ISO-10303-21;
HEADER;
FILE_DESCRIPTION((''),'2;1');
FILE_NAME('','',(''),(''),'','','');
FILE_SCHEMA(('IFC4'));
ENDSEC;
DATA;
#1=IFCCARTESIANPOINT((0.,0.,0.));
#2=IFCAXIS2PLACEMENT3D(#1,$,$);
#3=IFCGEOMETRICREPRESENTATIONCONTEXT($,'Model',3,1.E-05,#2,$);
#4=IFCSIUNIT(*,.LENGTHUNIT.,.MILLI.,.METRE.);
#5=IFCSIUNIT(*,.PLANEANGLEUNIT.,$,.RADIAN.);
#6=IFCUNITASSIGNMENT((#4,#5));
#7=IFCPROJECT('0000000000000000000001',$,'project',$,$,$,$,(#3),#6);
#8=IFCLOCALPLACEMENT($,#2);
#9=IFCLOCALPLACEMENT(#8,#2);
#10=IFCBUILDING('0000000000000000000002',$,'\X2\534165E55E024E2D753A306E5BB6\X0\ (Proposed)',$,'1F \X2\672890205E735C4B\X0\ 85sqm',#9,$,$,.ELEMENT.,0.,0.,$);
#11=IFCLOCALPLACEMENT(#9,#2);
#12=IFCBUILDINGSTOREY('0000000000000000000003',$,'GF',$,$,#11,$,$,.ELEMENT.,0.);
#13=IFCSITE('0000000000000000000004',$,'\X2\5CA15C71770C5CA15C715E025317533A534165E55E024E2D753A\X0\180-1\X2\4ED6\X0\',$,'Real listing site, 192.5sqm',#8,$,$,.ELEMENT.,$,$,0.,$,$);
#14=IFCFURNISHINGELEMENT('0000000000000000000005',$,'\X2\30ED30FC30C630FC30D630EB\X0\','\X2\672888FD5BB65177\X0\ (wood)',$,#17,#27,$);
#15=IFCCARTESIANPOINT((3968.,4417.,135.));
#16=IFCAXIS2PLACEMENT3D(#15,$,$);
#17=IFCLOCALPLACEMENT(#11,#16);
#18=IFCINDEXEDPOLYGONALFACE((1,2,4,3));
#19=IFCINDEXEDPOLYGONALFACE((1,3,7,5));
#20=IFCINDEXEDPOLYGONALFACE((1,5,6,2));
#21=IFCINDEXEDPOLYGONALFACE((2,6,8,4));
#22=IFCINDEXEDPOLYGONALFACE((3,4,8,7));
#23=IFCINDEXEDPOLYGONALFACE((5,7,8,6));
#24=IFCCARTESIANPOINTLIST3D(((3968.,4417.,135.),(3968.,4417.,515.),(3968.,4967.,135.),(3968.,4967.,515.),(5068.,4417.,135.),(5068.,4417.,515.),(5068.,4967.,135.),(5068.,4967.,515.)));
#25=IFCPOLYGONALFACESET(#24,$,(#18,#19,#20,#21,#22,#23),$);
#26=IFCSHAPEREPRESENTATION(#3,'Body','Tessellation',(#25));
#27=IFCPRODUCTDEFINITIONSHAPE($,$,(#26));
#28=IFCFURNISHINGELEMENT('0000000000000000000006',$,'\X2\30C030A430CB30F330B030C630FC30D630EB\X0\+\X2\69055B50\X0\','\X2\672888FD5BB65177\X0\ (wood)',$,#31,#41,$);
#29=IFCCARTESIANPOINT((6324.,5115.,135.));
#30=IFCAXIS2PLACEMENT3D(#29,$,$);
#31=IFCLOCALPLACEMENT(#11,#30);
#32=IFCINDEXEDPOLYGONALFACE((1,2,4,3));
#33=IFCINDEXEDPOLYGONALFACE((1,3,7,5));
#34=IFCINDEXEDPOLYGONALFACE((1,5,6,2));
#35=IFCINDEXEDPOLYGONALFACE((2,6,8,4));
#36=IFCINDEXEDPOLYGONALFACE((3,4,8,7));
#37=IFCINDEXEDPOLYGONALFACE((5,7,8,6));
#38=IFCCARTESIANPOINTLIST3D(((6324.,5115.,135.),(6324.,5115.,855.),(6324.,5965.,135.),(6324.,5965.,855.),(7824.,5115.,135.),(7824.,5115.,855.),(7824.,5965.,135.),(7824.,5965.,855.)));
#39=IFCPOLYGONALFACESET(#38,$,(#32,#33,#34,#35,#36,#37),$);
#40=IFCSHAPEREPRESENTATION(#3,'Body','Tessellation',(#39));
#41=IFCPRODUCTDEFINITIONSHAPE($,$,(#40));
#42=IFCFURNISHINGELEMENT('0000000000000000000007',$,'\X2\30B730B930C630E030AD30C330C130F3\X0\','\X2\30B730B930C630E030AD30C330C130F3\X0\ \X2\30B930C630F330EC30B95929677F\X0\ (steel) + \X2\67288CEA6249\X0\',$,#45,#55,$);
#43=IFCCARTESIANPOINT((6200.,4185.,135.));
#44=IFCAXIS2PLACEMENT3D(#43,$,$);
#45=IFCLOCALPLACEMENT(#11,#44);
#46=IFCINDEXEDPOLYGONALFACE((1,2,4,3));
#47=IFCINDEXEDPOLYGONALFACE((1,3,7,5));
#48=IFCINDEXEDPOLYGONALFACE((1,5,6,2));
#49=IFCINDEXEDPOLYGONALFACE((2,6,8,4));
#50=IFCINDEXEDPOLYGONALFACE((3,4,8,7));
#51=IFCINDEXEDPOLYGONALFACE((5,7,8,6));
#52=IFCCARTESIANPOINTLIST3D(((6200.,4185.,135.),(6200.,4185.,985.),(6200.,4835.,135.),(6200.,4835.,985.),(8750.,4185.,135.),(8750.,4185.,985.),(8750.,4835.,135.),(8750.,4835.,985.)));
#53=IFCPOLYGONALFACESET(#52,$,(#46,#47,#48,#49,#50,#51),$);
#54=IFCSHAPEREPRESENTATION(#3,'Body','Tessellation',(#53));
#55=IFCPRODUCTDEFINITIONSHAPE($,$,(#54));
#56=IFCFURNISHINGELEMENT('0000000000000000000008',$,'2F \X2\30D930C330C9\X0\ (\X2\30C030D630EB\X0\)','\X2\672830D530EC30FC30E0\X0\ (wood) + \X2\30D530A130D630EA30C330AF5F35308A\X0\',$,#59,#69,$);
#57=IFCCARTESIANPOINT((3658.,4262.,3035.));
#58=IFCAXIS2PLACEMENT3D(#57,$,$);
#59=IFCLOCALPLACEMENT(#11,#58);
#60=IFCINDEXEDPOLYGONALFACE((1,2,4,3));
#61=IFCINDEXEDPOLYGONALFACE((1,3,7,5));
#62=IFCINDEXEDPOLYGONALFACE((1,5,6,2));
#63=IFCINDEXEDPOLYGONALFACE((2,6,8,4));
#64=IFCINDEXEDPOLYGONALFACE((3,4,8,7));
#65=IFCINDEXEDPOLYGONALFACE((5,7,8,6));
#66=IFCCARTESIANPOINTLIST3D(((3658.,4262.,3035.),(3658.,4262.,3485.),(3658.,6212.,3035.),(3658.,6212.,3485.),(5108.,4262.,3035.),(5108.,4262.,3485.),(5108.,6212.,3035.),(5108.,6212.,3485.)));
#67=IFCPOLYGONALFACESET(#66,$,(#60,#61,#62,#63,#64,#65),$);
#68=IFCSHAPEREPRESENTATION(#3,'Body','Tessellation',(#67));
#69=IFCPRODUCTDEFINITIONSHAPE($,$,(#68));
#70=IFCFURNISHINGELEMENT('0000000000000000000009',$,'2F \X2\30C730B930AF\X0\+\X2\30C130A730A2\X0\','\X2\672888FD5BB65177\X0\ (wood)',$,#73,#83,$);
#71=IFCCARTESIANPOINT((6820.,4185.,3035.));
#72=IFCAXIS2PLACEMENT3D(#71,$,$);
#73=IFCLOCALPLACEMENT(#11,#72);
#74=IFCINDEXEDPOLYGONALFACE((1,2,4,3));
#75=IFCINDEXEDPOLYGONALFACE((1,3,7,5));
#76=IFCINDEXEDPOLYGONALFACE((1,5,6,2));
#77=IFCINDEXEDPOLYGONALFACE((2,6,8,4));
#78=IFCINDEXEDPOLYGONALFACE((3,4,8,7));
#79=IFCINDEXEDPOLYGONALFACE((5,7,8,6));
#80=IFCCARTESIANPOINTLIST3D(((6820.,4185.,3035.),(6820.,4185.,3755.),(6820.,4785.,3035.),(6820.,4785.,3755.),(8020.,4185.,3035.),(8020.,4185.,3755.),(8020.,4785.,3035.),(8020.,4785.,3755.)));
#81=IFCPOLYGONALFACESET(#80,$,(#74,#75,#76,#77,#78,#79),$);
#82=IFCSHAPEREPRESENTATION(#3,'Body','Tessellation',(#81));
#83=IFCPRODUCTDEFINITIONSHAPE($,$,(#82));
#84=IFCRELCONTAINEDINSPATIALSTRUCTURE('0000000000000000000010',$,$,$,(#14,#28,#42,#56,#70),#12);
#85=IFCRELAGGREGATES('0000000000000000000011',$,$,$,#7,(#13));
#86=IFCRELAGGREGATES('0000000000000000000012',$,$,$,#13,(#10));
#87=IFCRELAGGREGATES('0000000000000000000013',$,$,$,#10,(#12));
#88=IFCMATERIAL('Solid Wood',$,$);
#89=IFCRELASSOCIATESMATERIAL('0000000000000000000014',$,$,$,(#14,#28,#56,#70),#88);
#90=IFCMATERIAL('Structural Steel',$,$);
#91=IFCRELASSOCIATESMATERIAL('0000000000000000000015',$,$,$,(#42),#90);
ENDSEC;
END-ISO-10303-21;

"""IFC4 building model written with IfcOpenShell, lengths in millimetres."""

from ifc_helpers import new_model, si_unit, frame, frame_2d, origin, place, context, project, spatial, rectangle, extrude, material, element, save


model = new_model("IFC4")

# Units and contexts
model_context = context("Model", 3, precision=1e-05, world=origin())
ifc_project = project(units=[si_unit("LENGTHUNIT", "METRE", prefix="MILLI"), si_unit("PLANEANGLEUNIT", "RADIAN")], contexts=[model_context])

# Site, building, storey
site_placement = place(None, origin())
site = spatial("IfcSite", under=ifc_project, at=site_placement, Name="岡山県岡山市北区十日市中町180-1他", ObjectType="Real listing site, 192.5sqm", CompositionType="ELEMENT", RefElevation=0.0)
building_placement = place(site_placement, origin())
building = spatial("IfcBuilding", under=site, at=building_placement, Name="十日市中町の家 (Proposed)", ObjectType="1F 木造平屋 85sqm", CompositionType="ELEMENT", ElevationOfRefHeight=0.0, ElevationOfTerrain=0.0)
storey_placement = place(building_placement, origin())
storey = spatial("IfcBuildingStorey", under=building, at=storey_placement, Name="GF", CompositionType="ELEMENT", Elevation=0.0)

# Shared definitions
ifc_material_1 = material(Name="Solid Wood")

# Shared definitions
ifc_material_2 = material(Name="Structural Steel")

# Furnishing elements
furnishing_1_placement = place(storey_placement, frame((3968.0, 4417.0, 135.0)))
element("IfcFurnishingElement", 1, at=furnishing_1_placement, inside=storey, material=ifc_material_1, Name="ローテーブル", Description="木製家具 (wood)", context=model_context, shape_type="SweptSolid", body=[
    extrude(rectangle(XDim=1100.0, YDim=550.0, at=frame_2d((550.0, 275.0))), frame((3968.0, 4417.0, 135.0)), (0.0, 0.0, 1.0), 380.0),
])
furnishing_2_placement = place(storey_placement, frame((6324.0, 5115.0, 135.0)))
element("IfcFurnishingElement", 2, at=furnishing_2_placement, inside=storey, material=ifc_material_1, Name="ダイニングテーブル+椅子", Description="木製家具 (wood)", context=model_context, shape_type="SweptSolid", body=[
    extrude(rectangle(XDim=1500.0, YDim=850.0, at=frame_2d((750.0, 425.0))), frame((6324.0, 5115.0, 135.0)), (0.0, 0.0, 1.0), 720.0),
])
furnishing_3_placement = place(storey_placement, frame((6200.0, 4185.0, 135.0)))
element("IfcFurnishingElement", 3, at=furnishing_3_placement, inside=storey, material=ifc_material_2, Name="システムキッチン", Description="システムキッチン ステンレス天板 (steel) + 木質扉", context=model_context, shape_type="SweptSolid", body=[
    extrude(rectangle(XDim=2550.0, YDim=650.0, at=frame_2d((1275.0, 325.0))), frame((6200.0, 4185.0, 135.0)), (0.0, 0.0, 1.0), 850.0),
])
furnishing_4_placement = place(storey_placement, frame((3658.0, 4262.0, 3035.0)))
element("IfcFurnishingElement", 4, at=furnishing_4_placement, inside=storey, material=ifc_material_1, Name="2F ベッド (ダブル)", Description="木フレーム (wood) + ファブリック張り", context=model_context, shape_type="SweptSolid", body=[
    extrude(rectangle(XDim=1450.0, YDim=1950.0, at=frame_2d((725.0, 975.0))), frame((3658.0, 4262.0, 3035.0)), (0.0, 0.0, 1.0), 450.0),
])
furnishing_5_placement = place(storey_placement, frame((6820.0, 4185.0, 3035.0)))
element("IfcFurnishingElement", 5, at=furnishing_5_placement, inside=storey, material=ifc_material_1, Name="2F デスク+チェア", Description="木製家具 (wood)", context=model_context, shape_type="SweptSolid", body=[
    extrude(rectangle(XDim=1200.0, YDim=600.0, at=frame_2d((600.0, 300.0))), frame((6820.0, 4185.0, 3035.0)), (0.0, 0.0, 1.0), 720.0),
])

save(model, "model.ifc")
